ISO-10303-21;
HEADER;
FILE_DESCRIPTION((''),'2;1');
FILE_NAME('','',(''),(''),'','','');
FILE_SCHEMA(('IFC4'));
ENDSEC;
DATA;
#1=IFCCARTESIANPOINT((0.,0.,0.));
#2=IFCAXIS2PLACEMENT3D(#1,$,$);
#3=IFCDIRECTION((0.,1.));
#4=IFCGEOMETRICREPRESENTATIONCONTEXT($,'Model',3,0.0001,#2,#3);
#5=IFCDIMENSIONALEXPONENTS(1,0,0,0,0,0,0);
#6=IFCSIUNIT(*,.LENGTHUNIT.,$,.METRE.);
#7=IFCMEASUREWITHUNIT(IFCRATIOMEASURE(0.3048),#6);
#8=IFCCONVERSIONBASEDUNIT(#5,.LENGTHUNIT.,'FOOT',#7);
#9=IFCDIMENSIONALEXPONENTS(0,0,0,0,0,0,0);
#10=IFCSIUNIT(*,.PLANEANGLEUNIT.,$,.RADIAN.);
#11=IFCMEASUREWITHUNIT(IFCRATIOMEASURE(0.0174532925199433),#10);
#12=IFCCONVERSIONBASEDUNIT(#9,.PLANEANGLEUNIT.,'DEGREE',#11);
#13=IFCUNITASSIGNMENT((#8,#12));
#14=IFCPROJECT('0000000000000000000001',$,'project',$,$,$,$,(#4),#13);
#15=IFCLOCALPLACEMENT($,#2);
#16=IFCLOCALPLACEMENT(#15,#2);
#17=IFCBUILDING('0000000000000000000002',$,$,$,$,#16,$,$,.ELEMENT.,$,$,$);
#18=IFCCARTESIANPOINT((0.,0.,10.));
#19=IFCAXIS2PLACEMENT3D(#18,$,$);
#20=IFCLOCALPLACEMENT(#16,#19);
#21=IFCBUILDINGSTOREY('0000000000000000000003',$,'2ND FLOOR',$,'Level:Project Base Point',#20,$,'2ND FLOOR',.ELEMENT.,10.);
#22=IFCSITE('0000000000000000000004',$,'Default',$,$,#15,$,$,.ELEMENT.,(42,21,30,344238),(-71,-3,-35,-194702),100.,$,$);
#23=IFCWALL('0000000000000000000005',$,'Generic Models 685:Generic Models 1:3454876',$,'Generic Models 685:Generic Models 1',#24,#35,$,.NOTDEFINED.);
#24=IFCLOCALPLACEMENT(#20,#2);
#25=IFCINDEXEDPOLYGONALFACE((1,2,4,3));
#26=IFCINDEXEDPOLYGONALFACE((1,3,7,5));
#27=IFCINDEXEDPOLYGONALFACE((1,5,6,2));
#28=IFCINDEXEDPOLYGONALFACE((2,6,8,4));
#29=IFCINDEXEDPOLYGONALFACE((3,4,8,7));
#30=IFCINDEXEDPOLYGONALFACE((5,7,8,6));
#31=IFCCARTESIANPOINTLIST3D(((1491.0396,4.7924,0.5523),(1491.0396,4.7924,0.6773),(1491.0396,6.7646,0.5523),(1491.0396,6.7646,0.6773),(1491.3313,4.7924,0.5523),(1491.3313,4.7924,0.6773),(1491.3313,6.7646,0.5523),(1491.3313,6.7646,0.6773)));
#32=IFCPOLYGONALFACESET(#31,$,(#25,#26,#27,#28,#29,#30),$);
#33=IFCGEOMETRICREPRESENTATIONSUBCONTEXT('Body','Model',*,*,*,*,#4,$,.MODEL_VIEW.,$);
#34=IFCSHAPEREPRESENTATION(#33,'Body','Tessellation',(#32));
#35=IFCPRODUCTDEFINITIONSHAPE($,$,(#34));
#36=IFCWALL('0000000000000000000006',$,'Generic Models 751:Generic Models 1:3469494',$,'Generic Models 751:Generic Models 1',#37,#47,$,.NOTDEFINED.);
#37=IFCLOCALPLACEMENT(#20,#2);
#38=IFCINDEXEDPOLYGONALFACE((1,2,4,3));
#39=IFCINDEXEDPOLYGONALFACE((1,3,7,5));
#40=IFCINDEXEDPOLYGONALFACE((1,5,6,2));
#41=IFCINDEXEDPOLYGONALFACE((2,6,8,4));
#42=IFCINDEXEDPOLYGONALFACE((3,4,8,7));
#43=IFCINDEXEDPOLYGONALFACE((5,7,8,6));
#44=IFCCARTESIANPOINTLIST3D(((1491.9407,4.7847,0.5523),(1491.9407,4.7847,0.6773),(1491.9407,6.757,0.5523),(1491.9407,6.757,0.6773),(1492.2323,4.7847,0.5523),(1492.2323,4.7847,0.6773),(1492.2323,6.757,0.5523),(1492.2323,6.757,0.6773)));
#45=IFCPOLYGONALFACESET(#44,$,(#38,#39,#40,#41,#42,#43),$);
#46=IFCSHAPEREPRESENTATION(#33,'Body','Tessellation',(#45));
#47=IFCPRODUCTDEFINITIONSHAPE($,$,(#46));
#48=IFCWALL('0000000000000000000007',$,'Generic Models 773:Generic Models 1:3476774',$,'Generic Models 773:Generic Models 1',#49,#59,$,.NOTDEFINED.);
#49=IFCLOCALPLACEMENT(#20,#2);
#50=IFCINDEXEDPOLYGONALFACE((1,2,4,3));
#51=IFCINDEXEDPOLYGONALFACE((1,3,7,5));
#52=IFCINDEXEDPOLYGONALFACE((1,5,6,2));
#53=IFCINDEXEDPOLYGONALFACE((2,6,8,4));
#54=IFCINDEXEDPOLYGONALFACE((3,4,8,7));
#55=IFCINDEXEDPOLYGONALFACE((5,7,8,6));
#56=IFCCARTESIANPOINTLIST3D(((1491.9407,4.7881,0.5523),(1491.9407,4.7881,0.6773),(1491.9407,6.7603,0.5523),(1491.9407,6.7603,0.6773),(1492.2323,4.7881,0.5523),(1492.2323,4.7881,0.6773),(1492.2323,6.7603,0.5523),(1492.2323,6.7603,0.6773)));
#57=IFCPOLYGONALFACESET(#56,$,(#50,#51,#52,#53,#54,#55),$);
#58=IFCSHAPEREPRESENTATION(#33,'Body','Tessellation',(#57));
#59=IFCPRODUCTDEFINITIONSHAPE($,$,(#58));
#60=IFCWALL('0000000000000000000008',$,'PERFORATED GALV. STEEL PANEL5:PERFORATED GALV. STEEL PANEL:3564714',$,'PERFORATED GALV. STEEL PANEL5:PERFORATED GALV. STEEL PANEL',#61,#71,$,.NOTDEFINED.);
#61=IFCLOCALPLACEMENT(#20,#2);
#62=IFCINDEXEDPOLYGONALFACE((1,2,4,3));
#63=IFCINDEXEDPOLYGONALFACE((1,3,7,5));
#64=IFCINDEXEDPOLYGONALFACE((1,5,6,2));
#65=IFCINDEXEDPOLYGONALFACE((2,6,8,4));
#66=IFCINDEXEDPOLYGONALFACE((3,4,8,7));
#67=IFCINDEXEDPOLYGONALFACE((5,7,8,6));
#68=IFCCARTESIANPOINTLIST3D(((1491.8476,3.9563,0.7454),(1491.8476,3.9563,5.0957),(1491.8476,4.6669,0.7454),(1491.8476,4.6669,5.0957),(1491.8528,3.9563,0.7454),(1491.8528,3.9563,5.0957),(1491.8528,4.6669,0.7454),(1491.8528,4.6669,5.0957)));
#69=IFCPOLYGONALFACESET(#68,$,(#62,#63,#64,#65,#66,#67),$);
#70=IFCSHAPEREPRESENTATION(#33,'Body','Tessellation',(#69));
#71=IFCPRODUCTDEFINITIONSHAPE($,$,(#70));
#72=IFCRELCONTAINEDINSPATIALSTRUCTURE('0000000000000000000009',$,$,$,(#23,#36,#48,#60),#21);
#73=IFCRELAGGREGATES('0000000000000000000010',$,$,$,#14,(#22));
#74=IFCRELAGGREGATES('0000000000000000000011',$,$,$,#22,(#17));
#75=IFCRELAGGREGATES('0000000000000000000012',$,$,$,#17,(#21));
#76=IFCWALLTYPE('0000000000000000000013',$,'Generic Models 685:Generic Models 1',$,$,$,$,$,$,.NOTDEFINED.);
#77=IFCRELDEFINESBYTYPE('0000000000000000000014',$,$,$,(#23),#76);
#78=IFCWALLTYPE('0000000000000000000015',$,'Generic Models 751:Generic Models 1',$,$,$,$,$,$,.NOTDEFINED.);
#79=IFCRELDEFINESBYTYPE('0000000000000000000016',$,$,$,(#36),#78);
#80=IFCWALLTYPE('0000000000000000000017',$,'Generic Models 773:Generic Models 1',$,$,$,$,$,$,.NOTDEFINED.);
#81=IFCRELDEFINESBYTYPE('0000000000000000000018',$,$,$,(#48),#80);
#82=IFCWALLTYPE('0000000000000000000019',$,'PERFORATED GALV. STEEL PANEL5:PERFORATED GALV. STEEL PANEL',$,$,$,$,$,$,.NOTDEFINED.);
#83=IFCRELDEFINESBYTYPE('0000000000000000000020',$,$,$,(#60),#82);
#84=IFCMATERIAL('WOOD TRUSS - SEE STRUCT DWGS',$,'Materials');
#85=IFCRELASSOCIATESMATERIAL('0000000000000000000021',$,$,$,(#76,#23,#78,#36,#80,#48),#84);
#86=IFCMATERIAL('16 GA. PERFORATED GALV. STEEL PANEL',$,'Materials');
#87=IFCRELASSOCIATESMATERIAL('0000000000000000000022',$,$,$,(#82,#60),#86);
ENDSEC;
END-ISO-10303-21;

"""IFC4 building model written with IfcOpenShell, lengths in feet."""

from ifc_helpers import new_model, entity, si_unit, converted_unit, direction, frame, frame_2d, origin, origin_2d_with_axis, place, context, subcontext, project, spatial, rectangle, extrude, material, type_object, element, save


model = new_model("IFC4")

# Units and contexts
model_context = context("Model", 3, precision=0.0001, world=origin(), true_north=direction((0.0, 1.0)))
body_context = subcontext(model_context, "Body", "Model", "MODEL_VIEW")
ifc_project = project(units=[converted_unit("LENGTHUNIT", "FOOT", entity("IfcRatioMeasure", 0.3048), si_unit("LENGTHUNIT", "METRE"), dimensions=[1, 0, 0, 0, 0, 0, 0]), converted_unit("PLANEANGLEUNIT", "DEGREE", entity("IfcRatioMeasure", 0.0174532925199433), si_unit("PLANEANGLEUNIT", "RADIAN"), dimensions=[0, 0, 0, 0, 0, 0, 0])], contexts=[model_context])

# Site, building, storey
site_placement = place(None, origin())
site = spatial("IfcSite", under=ifc_project, at=site_placement, Name="Default", CompositionType="ELEMENT", RefLatitude=(42, 21, 30, 344238), RefLongitude=(-71, -3, -35, -194702), RefElevation=100.0)
building_placement = place(site_placement, origin())
building = spatial("IfcBuilding", under=site, at=building_placement, CompositionType="ELEMENT")
storey_placement = place(building_placement, frame((0.0, 0.0, 10.0)))
storey = spatial("IfcBuildingStorey", under=building, at=storey_placement, Name="2ND FLOOR", ObjectType="Level:Project Base Point", LongName="2ND FLOOR", CompositionType="ELEMENT", Elevation=10.0)

# Walls
ifc_material_1 = material(Name="WOOD TRUSS - SEE STRUCT DWGS", Category="Materials")
wall_type_1 = type_object("IfcWallType", Name="Generic Models 685:Generic Models 1", PredefinedType="NOTDEFINED", material=ifc_material_1)
wall_1_placement = place(storey_placement, frame((1491.0396, 4.7924, 0.5523), z_axis=(0.0, 0.0, 1.0), x_axis=(0.0, 1.0, 0.0)))
element("IfcWall", 1, at=wall_1_placement, inside=storey, type_object=wall_type_1, material=ifc_material_1, Name="Generic Models 685:Generic Models 1:3454876", ObjectType="Generic Models 685:Generic Models 1", PredefinedType="NOTDEFINED", context=body_context, shape_type="SweptSolid", body=[
    extrude(rectangle(XDim=1.9723, YDim=0.2917, at=origin_2d_with_axis()), frame((0.9861, -0.1458, 0.0)), (0.0, 0.0, 1.0), 0.125),
])
wall_type_2 = type_object("IfcWallType", Name="Generic Models 751:Generic Models 1", PredefinedType="NOTDEFINED", material=ifc_material_1)
wall_2_placement = place(storey_placement, frame((1491.9407, 4.7847, 0.5523), z_axis=(0.0, 0.0, 1.0), x_axis=(0.0, 1.0, 0.0)))
element("IfcWall", 2, at=wall_2_placement, inside=storey, type_object=wall_type_2, material=ifc_material_1, Name="Generic Models 751:Generic Models 1:3469494", ObjectType="Generic Models 751:Generic Models 1", PredefinedType="NOTDEFINED", context=body_context, shape_type="SweptSolid", body=[
    extrude(rectangle(XDim=1.9723, YDim=0.2917, at=frame_2d((0.0, 0.0), x_axis=(1.0, 0.0))), frame((0.9861, -0.1458, 0.0)), (0.0, 0.0, 1.0), 0.125),
])
wall_type_3 = type_object("IfcWallType", Name="Generic Models 773:Generic Models 1", PredefinedType="NOTDEFINED", material=ifc_material_1)
wall_3_placement = place(storey_placement, frame((1491.9407, 4.7881, 0.5523), z_axis=(0.0, 0.0, 1.0), x_axis=(0.0, 1.0, 0.0)))
element("IfcWall", 3, at=wall_3_placement, inside=storey, type_object=wall_type_3, material=ifc_material_1, Name="Generic Models 773:Generic Models 1:3476774", ObjectType="Generic Models 773:Generic Models 1", PredefinedType="NOTDEFINED", context=body_context, shape_type="SweptSolid", body=[
    extrude(rectangle(XDim=1.9723, YDim=0.2917, at=frame_2d((0.0, 0.0), x_axis=(1.0, 0.0))), frame((0.9861, -0.1458, 0.0)), (0.0, 0.0, 1.0), 0.125),
])
ifc_material_2 = material(Name="16 GA. PERFORATED GALV. STEEL PANEL", Category="Materials")
wall_type_4 = type_object("IfcWallType", Name="PERFORATED GALV. STEEL PANEL5:PERFORATED GALV. STEEL PANEL", PredefinedType="NOTDEFINED", material=ifc_material_2)
wall_4_placement = place(storey_placement, frame((1491.8476, 3.9563, 0.7454), z_axis=(0.0, 0.0, 1.0), x_axis=(0.0, 1.0, 0.0)))
element("IfcWall", 4, at=wall_4_placement, inside=storey, type_object=wall_type_4, material=ifc_material_2, Name="PERFORATED GALV. STEEL PANEL5:PERFORATED GALV. STEEL PANEL:3564714", ObjectType="PERFORATED GALV. STEEL PANEL5:PERFORATED GALV. STEEL PANEL", PredefinedType="NOTDEFINED", context=body_context, shape_type="SweptSolid", body=[
    extrude(rectangle(XDim=0.7107, YDim=0.0052, at=frame_2d((0.0, 0.0), x_axis=(1.0, 0.0))), frame((0.3553, -0.0026, 0.0), z_axis=(0.0, 0.0, 1.0), x_axis=(-1.0, 0.0, 0.0)), (0.0, 0.0, 1.0), 4.3503),
])

save(model, "model.ifc")
